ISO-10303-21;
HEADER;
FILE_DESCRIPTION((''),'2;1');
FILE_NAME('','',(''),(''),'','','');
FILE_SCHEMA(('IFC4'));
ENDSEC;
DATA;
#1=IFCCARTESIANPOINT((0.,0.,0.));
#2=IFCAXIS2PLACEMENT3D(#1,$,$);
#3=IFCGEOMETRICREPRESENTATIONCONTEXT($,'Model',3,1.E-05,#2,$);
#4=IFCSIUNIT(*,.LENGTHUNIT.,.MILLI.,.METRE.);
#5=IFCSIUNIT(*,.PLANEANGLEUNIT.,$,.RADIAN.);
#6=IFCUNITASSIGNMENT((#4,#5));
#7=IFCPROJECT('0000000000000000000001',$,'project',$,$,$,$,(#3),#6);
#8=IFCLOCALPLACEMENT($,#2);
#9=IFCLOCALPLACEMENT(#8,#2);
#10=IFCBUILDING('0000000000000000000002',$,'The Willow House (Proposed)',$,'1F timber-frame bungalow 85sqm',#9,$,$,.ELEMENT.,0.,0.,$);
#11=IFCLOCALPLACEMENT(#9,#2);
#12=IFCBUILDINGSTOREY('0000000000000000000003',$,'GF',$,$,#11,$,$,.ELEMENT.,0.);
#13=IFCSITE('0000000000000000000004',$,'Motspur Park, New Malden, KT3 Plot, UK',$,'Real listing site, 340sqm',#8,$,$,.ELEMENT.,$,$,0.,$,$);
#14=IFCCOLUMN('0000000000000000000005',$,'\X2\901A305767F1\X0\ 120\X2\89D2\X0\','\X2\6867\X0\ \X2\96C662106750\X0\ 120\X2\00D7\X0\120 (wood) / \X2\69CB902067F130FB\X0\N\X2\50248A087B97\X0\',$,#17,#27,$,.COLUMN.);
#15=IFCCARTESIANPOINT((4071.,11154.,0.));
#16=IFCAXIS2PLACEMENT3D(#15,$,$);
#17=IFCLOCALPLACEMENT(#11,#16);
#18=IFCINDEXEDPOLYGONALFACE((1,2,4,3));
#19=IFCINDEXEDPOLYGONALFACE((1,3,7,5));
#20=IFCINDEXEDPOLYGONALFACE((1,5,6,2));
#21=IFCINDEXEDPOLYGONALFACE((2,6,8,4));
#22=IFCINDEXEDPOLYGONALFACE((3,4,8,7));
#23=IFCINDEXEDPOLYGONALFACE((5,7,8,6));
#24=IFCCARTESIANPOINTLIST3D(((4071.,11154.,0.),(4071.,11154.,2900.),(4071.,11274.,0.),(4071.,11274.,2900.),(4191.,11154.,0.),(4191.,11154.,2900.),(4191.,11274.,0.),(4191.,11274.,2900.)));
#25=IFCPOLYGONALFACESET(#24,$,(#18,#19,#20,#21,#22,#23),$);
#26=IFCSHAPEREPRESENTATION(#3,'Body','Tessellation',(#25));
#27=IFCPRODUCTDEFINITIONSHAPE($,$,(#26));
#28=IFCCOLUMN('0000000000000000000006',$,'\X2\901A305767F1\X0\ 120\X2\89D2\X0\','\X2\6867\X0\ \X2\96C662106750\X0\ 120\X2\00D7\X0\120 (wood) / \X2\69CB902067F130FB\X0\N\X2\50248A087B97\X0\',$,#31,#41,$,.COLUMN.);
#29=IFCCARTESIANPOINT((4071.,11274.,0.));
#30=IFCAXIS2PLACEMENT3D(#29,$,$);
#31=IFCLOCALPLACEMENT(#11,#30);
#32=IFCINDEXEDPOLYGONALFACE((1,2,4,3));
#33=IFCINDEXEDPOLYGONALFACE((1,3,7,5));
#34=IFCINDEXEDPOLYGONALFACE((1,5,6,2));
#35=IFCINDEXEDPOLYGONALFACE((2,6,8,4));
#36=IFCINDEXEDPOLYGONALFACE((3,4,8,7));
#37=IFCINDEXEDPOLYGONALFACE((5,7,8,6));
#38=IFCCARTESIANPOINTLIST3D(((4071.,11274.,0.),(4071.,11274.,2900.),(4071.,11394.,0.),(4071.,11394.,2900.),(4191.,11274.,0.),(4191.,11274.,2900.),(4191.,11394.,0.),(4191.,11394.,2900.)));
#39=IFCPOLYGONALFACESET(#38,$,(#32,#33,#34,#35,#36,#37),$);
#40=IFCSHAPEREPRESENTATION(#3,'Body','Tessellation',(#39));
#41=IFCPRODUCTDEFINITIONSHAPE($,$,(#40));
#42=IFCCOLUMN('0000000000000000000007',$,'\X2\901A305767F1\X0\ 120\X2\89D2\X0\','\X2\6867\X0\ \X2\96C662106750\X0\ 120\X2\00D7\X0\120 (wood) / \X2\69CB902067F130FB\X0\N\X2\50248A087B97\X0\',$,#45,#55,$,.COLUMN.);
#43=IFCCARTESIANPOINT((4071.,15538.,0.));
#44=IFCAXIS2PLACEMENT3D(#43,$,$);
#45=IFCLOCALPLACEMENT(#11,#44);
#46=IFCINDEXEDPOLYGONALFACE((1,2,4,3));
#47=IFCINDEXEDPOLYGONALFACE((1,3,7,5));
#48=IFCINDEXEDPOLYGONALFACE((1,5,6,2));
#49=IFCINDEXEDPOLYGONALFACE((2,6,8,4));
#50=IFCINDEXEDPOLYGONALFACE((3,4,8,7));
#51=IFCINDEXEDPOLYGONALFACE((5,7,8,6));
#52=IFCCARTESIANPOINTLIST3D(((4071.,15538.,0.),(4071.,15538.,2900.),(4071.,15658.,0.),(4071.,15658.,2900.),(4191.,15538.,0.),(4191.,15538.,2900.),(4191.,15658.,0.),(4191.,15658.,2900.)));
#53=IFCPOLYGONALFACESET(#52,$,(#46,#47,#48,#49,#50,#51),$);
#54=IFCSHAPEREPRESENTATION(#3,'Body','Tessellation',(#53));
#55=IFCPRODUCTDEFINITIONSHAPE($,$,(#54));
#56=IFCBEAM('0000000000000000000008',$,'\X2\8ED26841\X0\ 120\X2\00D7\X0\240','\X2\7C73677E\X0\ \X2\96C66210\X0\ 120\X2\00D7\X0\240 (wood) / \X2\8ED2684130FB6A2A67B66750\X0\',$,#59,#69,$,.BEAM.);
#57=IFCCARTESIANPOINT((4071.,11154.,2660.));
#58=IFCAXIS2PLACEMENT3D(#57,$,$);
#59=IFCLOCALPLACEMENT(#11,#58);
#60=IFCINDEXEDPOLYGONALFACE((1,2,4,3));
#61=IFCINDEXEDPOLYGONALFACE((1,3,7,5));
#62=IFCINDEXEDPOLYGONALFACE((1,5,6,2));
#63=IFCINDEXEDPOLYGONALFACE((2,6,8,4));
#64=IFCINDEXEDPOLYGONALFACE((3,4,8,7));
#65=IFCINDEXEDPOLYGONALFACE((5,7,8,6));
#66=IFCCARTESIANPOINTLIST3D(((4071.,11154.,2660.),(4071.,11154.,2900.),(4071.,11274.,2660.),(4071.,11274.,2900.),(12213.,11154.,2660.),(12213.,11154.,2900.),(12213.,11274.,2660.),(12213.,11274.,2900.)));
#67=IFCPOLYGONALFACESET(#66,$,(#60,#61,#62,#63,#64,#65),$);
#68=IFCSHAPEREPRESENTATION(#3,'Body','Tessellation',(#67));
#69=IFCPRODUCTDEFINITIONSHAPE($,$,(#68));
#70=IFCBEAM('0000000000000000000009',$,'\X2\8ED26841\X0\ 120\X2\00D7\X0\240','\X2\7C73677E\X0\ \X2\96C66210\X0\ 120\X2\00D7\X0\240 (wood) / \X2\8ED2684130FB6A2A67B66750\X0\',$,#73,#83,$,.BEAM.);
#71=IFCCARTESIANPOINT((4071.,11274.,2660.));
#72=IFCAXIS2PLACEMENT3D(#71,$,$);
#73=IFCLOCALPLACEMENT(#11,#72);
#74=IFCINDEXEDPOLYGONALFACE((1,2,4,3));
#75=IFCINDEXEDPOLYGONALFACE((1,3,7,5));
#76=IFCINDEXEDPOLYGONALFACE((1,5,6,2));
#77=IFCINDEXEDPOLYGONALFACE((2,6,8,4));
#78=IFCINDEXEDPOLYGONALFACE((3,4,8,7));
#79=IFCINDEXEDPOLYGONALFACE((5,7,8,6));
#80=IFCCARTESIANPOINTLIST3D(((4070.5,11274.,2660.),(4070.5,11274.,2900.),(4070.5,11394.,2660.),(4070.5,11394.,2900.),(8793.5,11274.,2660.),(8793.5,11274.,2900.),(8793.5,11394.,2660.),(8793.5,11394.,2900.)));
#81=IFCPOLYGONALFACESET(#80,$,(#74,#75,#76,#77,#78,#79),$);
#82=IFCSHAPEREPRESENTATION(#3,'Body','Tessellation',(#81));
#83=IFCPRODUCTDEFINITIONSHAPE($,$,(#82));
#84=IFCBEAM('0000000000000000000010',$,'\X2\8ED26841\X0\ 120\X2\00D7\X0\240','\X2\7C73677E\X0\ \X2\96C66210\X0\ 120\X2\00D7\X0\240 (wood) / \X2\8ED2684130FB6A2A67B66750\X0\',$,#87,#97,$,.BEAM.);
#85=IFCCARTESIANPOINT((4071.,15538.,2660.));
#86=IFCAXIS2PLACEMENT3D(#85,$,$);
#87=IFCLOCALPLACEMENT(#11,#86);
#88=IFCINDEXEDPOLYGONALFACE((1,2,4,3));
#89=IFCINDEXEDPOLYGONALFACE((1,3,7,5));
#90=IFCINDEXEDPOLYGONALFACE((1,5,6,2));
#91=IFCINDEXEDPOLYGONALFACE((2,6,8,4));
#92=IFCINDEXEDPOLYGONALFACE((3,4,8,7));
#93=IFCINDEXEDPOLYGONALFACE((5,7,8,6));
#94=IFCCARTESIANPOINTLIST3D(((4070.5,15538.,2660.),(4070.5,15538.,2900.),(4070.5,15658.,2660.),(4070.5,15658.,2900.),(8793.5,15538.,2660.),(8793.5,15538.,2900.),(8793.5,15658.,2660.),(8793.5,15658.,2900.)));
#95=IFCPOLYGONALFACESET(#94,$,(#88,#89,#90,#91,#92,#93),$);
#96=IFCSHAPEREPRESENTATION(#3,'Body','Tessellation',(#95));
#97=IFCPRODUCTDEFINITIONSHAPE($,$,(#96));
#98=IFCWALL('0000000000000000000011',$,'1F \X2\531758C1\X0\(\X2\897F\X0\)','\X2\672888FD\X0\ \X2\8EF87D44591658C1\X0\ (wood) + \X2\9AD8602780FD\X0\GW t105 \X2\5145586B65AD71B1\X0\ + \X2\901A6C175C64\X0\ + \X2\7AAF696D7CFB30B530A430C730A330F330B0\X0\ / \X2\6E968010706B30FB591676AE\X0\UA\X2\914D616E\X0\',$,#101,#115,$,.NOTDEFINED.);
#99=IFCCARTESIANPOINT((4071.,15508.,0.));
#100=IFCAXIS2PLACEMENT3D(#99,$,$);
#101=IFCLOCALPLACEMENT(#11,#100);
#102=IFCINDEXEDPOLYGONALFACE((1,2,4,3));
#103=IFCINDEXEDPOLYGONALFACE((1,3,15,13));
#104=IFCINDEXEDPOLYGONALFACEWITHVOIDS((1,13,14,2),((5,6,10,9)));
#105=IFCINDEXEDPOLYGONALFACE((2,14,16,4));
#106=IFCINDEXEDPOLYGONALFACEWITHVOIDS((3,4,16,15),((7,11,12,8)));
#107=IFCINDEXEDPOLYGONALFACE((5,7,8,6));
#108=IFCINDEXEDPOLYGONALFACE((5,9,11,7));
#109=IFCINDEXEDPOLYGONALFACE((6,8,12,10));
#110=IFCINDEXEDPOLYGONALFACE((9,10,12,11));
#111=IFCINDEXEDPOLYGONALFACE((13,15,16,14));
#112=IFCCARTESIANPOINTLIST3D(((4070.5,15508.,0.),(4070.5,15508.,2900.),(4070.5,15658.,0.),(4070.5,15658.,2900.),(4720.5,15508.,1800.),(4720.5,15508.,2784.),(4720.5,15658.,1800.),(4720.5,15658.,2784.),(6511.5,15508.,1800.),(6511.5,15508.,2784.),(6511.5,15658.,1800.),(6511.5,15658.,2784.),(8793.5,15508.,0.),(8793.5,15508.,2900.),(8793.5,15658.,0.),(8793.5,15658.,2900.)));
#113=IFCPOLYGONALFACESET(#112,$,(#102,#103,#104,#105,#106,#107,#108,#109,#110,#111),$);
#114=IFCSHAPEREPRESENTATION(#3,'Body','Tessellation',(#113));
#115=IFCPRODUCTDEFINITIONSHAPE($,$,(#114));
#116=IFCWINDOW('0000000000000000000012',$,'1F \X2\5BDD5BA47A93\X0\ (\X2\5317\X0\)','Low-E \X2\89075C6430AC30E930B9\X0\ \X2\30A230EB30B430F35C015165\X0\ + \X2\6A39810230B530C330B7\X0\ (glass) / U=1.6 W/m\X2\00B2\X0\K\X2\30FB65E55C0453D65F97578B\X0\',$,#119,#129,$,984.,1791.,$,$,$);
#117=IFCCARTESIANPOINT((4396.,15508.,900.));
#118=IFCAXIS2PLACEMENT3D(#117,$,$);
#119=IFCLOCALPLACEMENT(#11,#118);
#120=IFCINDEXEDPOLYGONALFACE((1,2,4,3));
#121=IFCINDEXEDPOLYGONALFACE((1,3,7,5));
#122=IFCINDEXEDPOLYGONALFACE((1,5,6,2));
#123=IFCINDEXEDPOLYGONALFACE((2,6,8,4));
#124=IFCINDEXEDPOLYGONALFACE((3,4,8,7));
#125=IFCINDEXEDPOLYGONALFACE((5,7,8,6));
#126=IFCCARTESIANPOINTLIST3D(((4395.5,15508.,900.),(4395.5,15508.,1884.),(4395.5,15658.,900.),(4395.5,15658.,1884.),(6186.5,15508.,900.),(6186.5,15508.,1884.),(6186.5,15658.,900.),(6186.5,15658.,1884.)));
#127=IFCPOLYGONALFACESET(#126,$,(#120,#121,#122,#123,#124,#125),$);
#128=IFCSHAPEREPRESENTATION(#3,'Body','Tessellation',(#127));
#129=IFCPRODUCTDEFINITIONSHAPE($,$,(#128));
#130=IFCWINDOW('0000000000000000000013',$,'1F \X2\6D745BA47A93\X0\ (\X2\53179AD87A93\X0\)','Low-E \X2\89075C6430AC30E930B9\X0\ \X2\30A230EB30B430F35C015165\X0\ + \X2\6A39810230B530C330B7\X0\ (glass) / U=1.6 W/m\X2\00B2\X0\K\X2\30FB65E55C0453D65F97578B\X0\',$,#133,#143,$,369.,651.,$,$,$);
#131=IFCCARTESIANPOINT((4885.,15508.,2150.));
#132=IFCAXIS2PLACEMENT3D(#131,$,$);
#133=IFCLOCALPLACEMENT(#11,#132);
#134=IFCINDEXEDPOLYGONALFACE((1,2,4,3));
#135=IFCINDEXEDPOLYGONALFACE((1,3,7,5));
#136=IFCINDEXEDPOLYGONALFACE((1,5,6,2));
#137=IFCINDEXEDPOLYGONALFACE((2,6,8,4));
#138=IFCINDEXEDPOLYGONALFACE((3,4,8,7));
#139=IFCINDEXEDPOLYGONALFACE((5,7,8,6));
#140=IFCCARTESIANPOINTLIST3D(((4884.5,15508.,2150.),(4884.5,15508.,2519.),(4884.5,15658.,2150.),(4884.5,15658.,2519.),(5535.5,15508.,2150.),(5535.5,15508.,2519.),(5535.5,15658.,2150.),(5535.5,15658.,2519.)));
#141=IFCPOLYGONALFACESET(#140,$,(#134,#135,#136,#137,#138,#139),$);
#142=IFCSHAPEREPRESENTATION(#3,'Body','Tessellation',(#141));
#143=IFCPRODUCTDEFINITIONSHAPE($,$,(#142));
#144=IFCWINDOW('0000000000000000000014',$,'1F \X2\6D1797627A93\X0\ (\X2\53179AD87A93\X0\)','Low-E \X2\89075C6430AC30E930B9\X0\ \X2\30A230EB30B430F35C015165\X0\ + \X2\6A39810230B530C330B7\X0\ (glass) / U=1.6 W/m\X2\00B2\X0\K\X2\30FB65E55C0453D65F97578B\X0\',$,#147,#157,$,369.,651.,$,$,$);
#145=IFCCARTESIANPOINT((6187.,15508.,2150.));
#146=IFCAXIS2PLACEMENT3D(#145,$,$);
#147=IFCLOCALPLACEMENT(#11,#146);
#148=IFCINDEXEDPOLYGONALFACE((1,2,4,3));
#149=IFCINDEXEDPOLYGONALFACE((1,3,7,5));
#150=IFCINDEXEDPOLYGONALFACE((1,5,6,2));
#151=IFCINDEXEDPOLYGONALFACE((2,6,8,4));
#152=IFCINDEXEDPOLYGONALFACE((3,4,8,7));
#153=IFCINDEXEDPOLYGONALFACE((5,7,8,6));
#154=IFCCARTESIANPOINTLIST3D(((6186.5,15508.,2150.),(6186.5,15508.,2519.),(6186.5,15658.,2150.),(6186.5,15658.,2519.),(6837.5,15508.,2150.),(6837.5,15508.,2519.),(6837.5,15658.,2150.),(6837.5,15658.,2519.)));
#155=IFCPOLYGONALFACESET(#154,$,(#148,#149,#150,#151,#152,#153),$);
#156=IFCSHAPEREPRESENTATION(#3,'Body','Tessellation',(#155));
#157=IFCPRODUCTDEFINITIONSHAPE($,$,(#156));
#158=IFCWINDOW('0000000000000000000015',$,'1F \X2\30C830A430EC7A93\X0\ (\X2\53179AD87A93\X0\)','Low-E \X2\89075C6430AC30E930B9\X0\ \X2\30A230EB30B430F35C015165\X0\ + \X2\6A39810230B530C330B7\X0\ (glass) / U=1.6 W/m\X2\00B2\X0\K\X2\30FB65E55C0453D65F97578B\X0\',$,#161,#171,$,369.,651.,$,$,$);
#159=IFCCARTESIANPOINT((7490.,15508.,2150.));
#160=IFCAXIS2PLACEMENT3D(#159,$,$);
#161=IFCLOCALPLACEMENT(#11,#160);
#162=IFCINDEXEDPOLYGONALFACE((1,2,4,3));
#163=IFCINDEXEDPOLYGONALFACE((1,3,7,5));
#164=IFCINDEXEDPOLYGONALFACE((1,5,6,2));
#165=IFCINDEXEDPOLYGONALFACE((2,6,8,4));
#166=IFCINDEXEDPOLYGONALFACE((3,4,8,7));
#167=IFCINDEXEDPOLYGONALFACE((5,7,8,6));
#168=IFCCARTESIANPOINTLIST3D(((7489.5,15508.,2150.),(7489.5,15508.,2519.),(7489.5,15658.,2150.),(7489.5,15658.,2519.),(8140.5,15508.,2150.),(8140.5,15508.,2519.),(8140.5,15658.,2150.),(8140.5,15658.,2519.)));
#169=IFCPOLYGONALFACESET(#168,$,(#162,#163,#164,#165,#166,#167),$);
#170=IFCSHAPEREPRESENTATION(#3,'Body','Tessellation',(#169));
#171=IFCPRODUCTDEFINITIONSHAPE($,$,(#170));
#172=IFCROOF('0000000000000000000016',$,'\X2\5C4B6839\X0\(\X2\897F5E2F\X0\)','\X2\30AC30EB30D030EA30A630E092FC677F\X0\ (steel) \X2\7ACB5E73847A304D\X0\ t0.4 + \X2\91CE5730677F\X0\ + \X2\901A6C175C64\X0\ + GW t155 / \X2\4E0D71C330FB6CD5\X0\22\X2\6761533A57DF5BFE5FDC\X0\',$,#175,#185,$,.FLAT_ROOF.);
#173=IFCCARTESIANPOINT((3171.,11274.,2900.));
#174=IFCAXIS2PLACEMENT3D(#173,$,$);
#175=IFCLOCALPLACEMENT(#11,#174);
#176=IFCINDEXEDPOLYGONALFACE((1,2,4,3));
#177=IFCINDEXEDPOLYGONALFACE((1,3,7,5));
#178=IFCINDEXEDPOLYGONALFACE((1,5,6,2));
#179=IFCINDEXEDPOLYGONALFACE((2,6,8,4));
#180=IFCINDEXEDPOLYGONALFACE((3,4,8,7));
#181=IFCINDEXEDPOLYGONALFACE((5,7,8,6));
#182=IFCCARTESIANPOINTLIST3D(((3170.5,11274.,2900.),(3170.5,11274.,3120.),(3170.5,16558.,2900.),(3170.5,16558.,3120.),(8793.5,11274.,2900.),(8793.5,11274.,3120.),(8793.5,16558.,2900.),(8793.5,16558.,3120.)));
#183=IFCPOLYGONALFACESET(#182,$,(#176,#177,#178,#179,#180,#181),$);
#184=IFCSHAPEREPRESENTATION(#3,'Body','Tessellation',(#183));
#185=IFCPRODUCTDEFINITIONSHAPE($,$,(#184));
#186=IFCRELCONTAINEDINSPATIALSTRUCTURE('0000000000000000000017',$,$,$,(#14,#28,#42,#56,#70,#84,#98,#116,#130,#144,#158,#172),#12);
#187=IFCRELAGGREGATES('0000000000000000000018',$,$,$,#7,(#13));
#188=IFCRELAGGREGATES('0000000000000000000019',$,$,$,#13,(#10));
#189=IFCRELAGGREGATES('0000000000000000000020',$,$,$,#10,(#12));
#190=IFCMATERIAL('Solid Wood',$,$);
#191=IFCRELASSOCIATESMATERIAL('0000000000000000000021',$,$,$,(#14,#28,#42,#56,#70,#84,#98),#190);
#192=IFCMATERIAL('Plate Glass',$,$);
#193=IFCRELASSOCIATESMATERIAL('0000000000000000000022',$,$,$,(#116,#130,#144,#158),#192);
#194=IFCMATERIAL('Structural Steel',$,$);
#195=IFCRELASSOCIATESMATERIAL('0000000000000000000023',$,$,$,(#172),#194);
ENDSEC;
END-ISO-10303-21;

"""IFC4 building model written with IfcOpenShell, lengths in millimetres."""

from ifc_helpers import new_model, si_unit, frame, frame_2d, origin, place, context, project, spatial, rectangle, extrude, material, element, fill, save


model = new_model("IFC4")

# Units and contexts
model_context = context("Model", 3, precision=1e-05, world=origin())
ifc_project = project(units=[si_unit("LENGTHUNIT", "METRE", prefix="MILLI"), si_unit("PLANEANGLEUNIT", "RADIAN")], contexts=[model_context])

# Site, building, storey
site_placement = place(None, origin())
site = spatial("IfcSite", under=ifc_project, at=site_placement, Name="Motspur Park, New Malden, KT3 Plot, UK", ObjectType="Real listing site, 340sqm", CompositionType="ELEMENT", RefElevation=0.0)
building_placement = place(site_placement, origin())
building = spatial("IfcBuilding", under=site, at=building_placement, Name="The Willow House (Proposed)", ObjectType="1F timber-frame bungalow 85sqm", CompositionType="ELEMENT", ElevationOfRefHeight=0.0, ElevationOfTerrain=0.0)
storey_placement = place(building_placement, origin())
storey = spatial("IfcBuildingStorey", under=building, at=storey_placement, Name="GF", CompositionType="ELEMENT", Elevation=0.0)

# Columns
ifc_material_1 = material(Name="Solid Wood")
column_1_placement = place(storey_placement, frame((4071.0, 11154.0, 0.0)))
element("IfcColumn", 1, at=column_1_placement, inside=storey, material=ifc_material_1, Name="通し柱 120角", Description="桧 集成材 120×120 (wood) / 構造柱・N値計算", PredefinedType="COLUMN", context=model_context, shape_type="SweptSolid", body=[
    extrude(rectangle(XDim=120.0, YDim=120.0, at=frame_2d((60.0, 60.0))), frame((4071.0, 11154.0, 0.0)), (0.0, 0.0, 1.0), 2900.0),
])
column_2_placement = place(storey_placement, frame((4071.0, 11274.0, 0.0)))
element("IfcColumn", 2, at=column_2_placement, inside=storey, material=ifc_material_1, Name="通し柱 120角", Description="桧 集成材 120×120 (wood) / 構造柱・N値計算", PredefinedType="COLUMN", context=model_context, shape_type="SweptSolid", body=[
    extrude(rectangle(XDim=120.0, YDim=120.0, at=frame_2d((60.0, 60.0))), frame((4071.0, 11274.0, 0.0)), (0.0, 0.0, 1.0), 2900.0),
])
column_3_placement = place(storey_placement, frame((4071.0, 15538.0, 0.0)))
element("IfcColumn", 3, at=column_3_placement, inside=storey, material=ifc_material_1, Name="通し柱 120角", Description="桧 集成材 120×120 (wood) / 構造柱・N値計算", PredefinedType="COLUMN", context=model_context, shape_type="SweptSolid", body=[
    extrude(rectangle(XDim=120.0, YDim=120.0, at=frame_2d((60.0, 60.0))), frame((4071.0, 15538.0, 0.0)), (0.0, 0.0, 1.0), 2900.0),
])

# Beams
beam_1_placement = place(storey_placement, frame((4071.0, 11154.0, 2660.0)))
element("IfcBeam", 4, at=beam_1_placement, inside=storey, material=ifc_material_1, Name="軒桁 120×240", Description="米松 集成 120×240 (wood) / 軒桁・横架材", PredefinedType="BEAM", context=model_context, shape_type="SweptSolid", body=[
    extrude(rectangle(XDim=8142.0, YDim=120.0, at=frame_2d((4071.0, 60.0))), frame((4071.0, 11154.0, 2660.0)), (0.0, 0.0, 1.0), 240.0),
])
beam_2_placement = place(storey_placement, frame((4071.0, 11274.0, 2660.0)))
element("IfcBeam", 5, at=beam_2_placement, inside=storey, material=ifc_material_1, Name="軒桁 120×240", Description="米松 集成 120×240 (wood) / 軒桁・横架材", PredefinedType="BEAM", context=model_context, shape_type="SweptSolid", body=[
    extrude(rectangle(XDim=4723.0, YDim=120.0, at=frame_2d((2361.0, 60.0))), frame((4071.0, 11274.0, 2660.0)), (0.0, 0.0, 1.0), 240.0),
])
beam_3_placement = place(storey_placement, frame((4071.0, 15538.0, 2660.0)))
element("IfcBeam", 6, at=beam_3_placement, inside=storey, material=ifc_material_1, Name="軒桁 120×240", Description="米松 集成 120×240 (wood) / 軒桁・横架材", PredefinedType="BEAM", context=model_context, shape_type="SweptSolid", body=[
    extrude(rectangle(XDim=4723.0, YDim=120.0, at=frame_2d((2361.0, 60.0))), frame((4071.0, 15538.0, 2660.0)), (0.0, 0.0, 1.0), 240.0),
])

# Wall, openings, windows
wall_1_placement = place(storey_placement, frame((4071.0, 15508.0, 0.0)))
wall_1 = element("IfcWall", 7, at=wall_1_placement, inside=storey, material=ifc_material_1, Name="1F 北壁(西)", Description="木製 軸組外壁 (wood) + 高性能GW t105 充填断熱 + 通気層 + 窯業系サイディング / 準耐火・外皮UA配慮", PredefinedType="NOTDEFINED", context=model_context, shape_type="SweptSolid", body=[
    extrude(rectangle(XDim=4723.0, YDim=150.0, at=frame_2d((2361.0, 75.0))), frame((4071.0, 15508.0, 0.0)), (0.0, 0.0, 1.0), 2900.0),
])
opening_1_placement = place(storey_placement, frame((4396.0, 15508.0, 900.0)))
opening_1 = element("IfcOpeningElement", 8, at=opening_1_placement, cuts=wall_1, PredefinedType="NOTDEFINED", context=model_context, shape_type="SweptSolid", body=[
    extrude(rectangle(XDim=1791.0, YDim=150.0, at=frame_2d((895.0, 75.0))), frame((4396.0, 15508.0, 900.0)), (0.0, 0.0, 1.0), 984.0),
])
opening_2_placement = place(storey_placement, frame((4885.0, 15508.0, 2150.0)))
opening_2 = element("IfcOpeningElement", 9, at=opening_2_placement, cuts=wall_1, PredefinedType="NOTDEFINED", context=model_context, shape_type="SweptSolid", body=[
    extrude(rectangle(XDim=651.0, YDim=150.0, at=frame_2d((325.0, 75.0))), frame((4885.0, 15508.0, 2150.0)), (0.0, 0.0, 1.0), 369.0),
])
opening_3_placement = place(storey_placement, frame((6187.0, 15508.0, 2150.0)))
opening_3 = element("IfcOpeningElement", 10, at=opening_3_placement, cuts=wall_1, PredefinedType="NOTDEFINED", context=model_context, shape_type="SweptSolid", body=[
    extrude(rectangle(XDim=651.0, YDim=150.0, at=frame_2d((325.0, 75.0))), frame((6187.0, 15508.0, 2150.0)), (0.0, 0.0, 1.0), 369.0),
])
opening_4_placement = place(storey_placement, frame((7490.0, 15508.0, 2150.0)))
opening_4 = element("IfcOpeningElement", 11, at=opening_4_placement, cuts=wall_1, PredefinedType="NOTDEFINED", context=model_context, shape_type="SweptSolid", body=[
    extrude(rectangle(XDim=651.0, YDim=150.0, at=frame_2d((325.0, 75.0))), frame((7490.0, 15508.0, 2150.0)), (0.0, 0.0, 1.0), 369.0),
])
ifc_material_2 = material(Name="Plate Glass")
window_1_placement = place(storey_placement, frame((4396.0, 15508.0, 900.0)))
window_1 = element("IfcWindow", 12, at=window_1_placement, inside=storey, material=ifc_material_2, Name="1F 寝室窓 (北)", Description="Low-E 複層ガラス アルゴン封入 + 樹脂サッシ (glass) / U=1.6 W/m²K・日射取得型", OverallHeight=984.0, OverallWidth=1791.0, context=model_context, shape_type="SweptSolid", body=[
    extrude(rectangle(XDim=1791.0, YDim=150.0, at=frame_2d((895.0, 75.0))), frame((4396.0, 15508.0, 900.0)), (0.0, 0.0, 1.0), 984.0),
])
fill(opening_1, window_1)
window_2_placement = place(storey_placement, frame((4885.0, 15508.0, 2150.0)))
window_2 = element("IfcWindow", 13, at=window_2_placement, inside=storey, material=ifc_material_2, Name="1F 浴室窓 (北高窓)", Description="Low-E 複層ガラス アルゴン封入 + 樹脂サッシ (glass) / U=1.6 W/m²K・日射取得型", OverallHeight=369.0, OverallWidth=651.0, context=model_context, shape_type="SweptSolid", body=[
    extrude(rectangle(XDim=651.0, YDim=150.0, at=frame_2d((325.0, 75.0))), frame((4885.0, 15508.0, 2150.0)), (0.0, 0.0, 1.0), 369.0),
])
fill(opening_2, window_2)
window_3_placement = place(storey_placement, frame((6187.0, 15508.0, 2150.0)))
window_3 = element("IfcWindow", 14, at=window_3_placement, inside=storey, material=ifc_material_2, Name="1F 洗面窓 (北高窓)", Description="Low-E 複層ガラス アルゴン封入 + 樹脂サッシ (glass) / U=1.6 W/m²K・日射取得型", OverallHeight=369.0, OverallWidth=651.0, context=model_context, shape_type="SweptSolid", body=[
    extrude(rectangle(XDim=651.0, YDim=150.0, at=frame_2d((325.0, 75.0))), frame((6187.0, 15508.0, 2150.0)), (0.0, 0.0, 1.0), 369.0),
])
fill(opening_3, window_3)
window_4_placement = place(storey_placement, frame((7490.0, 15508.0, 2150.0)))
window_4 = element("IfcWindow", 15, at=window_4_placement, inside=storey, material=ifc_material_2, Name="1F トイレ窓 (北高窓)", Description="Low-E 複層ガラス アルゴン封入 + 樹脂サッシ (glass) / U=1.6 W/m²K・日射取得型", OverallHeight=369.0, OverallWidth=651.0, context=model_context, shape_type="SweptSolid", body=[
    extrude(rectangle(XDim=651.0, YDim=150.0, at=frame_2d((325.0, 75.0))), frame((7490.0, 15508.0, 2150.0)), (0.0, 0.0, 1.0), 369.0),
])
fill(opening_4, window_4)

# Roof
ifc_material_3 = material(Name="Structural Steel")
roof_placement = place(storey_placement, frame((3171.0, 11274.0, 2900.0)))
element("IfcRoof", 16, at=roof_placement, inside=storey, material=ifc_material_3, Name="屋根(西帯)", Description="ガルバリウム鋼板 (steel) 立平葺き t0.4 + 野地板 + 通気層 + GW t155 / 不燃・法22条区域対応", PredefinedType="FLAT_ROOF", context=model_context, shape_type="SweptSolid", body=[
    extrude(rectangle(XDim=5623.0, YDim=5284.0, at=frame_2d((2811.0, 2642.0))), frame((3171.0, 11274.0, 2900.0)), (0.0, 0.0, 1.0), 220.0),
])

save(model, "model.ifc")
